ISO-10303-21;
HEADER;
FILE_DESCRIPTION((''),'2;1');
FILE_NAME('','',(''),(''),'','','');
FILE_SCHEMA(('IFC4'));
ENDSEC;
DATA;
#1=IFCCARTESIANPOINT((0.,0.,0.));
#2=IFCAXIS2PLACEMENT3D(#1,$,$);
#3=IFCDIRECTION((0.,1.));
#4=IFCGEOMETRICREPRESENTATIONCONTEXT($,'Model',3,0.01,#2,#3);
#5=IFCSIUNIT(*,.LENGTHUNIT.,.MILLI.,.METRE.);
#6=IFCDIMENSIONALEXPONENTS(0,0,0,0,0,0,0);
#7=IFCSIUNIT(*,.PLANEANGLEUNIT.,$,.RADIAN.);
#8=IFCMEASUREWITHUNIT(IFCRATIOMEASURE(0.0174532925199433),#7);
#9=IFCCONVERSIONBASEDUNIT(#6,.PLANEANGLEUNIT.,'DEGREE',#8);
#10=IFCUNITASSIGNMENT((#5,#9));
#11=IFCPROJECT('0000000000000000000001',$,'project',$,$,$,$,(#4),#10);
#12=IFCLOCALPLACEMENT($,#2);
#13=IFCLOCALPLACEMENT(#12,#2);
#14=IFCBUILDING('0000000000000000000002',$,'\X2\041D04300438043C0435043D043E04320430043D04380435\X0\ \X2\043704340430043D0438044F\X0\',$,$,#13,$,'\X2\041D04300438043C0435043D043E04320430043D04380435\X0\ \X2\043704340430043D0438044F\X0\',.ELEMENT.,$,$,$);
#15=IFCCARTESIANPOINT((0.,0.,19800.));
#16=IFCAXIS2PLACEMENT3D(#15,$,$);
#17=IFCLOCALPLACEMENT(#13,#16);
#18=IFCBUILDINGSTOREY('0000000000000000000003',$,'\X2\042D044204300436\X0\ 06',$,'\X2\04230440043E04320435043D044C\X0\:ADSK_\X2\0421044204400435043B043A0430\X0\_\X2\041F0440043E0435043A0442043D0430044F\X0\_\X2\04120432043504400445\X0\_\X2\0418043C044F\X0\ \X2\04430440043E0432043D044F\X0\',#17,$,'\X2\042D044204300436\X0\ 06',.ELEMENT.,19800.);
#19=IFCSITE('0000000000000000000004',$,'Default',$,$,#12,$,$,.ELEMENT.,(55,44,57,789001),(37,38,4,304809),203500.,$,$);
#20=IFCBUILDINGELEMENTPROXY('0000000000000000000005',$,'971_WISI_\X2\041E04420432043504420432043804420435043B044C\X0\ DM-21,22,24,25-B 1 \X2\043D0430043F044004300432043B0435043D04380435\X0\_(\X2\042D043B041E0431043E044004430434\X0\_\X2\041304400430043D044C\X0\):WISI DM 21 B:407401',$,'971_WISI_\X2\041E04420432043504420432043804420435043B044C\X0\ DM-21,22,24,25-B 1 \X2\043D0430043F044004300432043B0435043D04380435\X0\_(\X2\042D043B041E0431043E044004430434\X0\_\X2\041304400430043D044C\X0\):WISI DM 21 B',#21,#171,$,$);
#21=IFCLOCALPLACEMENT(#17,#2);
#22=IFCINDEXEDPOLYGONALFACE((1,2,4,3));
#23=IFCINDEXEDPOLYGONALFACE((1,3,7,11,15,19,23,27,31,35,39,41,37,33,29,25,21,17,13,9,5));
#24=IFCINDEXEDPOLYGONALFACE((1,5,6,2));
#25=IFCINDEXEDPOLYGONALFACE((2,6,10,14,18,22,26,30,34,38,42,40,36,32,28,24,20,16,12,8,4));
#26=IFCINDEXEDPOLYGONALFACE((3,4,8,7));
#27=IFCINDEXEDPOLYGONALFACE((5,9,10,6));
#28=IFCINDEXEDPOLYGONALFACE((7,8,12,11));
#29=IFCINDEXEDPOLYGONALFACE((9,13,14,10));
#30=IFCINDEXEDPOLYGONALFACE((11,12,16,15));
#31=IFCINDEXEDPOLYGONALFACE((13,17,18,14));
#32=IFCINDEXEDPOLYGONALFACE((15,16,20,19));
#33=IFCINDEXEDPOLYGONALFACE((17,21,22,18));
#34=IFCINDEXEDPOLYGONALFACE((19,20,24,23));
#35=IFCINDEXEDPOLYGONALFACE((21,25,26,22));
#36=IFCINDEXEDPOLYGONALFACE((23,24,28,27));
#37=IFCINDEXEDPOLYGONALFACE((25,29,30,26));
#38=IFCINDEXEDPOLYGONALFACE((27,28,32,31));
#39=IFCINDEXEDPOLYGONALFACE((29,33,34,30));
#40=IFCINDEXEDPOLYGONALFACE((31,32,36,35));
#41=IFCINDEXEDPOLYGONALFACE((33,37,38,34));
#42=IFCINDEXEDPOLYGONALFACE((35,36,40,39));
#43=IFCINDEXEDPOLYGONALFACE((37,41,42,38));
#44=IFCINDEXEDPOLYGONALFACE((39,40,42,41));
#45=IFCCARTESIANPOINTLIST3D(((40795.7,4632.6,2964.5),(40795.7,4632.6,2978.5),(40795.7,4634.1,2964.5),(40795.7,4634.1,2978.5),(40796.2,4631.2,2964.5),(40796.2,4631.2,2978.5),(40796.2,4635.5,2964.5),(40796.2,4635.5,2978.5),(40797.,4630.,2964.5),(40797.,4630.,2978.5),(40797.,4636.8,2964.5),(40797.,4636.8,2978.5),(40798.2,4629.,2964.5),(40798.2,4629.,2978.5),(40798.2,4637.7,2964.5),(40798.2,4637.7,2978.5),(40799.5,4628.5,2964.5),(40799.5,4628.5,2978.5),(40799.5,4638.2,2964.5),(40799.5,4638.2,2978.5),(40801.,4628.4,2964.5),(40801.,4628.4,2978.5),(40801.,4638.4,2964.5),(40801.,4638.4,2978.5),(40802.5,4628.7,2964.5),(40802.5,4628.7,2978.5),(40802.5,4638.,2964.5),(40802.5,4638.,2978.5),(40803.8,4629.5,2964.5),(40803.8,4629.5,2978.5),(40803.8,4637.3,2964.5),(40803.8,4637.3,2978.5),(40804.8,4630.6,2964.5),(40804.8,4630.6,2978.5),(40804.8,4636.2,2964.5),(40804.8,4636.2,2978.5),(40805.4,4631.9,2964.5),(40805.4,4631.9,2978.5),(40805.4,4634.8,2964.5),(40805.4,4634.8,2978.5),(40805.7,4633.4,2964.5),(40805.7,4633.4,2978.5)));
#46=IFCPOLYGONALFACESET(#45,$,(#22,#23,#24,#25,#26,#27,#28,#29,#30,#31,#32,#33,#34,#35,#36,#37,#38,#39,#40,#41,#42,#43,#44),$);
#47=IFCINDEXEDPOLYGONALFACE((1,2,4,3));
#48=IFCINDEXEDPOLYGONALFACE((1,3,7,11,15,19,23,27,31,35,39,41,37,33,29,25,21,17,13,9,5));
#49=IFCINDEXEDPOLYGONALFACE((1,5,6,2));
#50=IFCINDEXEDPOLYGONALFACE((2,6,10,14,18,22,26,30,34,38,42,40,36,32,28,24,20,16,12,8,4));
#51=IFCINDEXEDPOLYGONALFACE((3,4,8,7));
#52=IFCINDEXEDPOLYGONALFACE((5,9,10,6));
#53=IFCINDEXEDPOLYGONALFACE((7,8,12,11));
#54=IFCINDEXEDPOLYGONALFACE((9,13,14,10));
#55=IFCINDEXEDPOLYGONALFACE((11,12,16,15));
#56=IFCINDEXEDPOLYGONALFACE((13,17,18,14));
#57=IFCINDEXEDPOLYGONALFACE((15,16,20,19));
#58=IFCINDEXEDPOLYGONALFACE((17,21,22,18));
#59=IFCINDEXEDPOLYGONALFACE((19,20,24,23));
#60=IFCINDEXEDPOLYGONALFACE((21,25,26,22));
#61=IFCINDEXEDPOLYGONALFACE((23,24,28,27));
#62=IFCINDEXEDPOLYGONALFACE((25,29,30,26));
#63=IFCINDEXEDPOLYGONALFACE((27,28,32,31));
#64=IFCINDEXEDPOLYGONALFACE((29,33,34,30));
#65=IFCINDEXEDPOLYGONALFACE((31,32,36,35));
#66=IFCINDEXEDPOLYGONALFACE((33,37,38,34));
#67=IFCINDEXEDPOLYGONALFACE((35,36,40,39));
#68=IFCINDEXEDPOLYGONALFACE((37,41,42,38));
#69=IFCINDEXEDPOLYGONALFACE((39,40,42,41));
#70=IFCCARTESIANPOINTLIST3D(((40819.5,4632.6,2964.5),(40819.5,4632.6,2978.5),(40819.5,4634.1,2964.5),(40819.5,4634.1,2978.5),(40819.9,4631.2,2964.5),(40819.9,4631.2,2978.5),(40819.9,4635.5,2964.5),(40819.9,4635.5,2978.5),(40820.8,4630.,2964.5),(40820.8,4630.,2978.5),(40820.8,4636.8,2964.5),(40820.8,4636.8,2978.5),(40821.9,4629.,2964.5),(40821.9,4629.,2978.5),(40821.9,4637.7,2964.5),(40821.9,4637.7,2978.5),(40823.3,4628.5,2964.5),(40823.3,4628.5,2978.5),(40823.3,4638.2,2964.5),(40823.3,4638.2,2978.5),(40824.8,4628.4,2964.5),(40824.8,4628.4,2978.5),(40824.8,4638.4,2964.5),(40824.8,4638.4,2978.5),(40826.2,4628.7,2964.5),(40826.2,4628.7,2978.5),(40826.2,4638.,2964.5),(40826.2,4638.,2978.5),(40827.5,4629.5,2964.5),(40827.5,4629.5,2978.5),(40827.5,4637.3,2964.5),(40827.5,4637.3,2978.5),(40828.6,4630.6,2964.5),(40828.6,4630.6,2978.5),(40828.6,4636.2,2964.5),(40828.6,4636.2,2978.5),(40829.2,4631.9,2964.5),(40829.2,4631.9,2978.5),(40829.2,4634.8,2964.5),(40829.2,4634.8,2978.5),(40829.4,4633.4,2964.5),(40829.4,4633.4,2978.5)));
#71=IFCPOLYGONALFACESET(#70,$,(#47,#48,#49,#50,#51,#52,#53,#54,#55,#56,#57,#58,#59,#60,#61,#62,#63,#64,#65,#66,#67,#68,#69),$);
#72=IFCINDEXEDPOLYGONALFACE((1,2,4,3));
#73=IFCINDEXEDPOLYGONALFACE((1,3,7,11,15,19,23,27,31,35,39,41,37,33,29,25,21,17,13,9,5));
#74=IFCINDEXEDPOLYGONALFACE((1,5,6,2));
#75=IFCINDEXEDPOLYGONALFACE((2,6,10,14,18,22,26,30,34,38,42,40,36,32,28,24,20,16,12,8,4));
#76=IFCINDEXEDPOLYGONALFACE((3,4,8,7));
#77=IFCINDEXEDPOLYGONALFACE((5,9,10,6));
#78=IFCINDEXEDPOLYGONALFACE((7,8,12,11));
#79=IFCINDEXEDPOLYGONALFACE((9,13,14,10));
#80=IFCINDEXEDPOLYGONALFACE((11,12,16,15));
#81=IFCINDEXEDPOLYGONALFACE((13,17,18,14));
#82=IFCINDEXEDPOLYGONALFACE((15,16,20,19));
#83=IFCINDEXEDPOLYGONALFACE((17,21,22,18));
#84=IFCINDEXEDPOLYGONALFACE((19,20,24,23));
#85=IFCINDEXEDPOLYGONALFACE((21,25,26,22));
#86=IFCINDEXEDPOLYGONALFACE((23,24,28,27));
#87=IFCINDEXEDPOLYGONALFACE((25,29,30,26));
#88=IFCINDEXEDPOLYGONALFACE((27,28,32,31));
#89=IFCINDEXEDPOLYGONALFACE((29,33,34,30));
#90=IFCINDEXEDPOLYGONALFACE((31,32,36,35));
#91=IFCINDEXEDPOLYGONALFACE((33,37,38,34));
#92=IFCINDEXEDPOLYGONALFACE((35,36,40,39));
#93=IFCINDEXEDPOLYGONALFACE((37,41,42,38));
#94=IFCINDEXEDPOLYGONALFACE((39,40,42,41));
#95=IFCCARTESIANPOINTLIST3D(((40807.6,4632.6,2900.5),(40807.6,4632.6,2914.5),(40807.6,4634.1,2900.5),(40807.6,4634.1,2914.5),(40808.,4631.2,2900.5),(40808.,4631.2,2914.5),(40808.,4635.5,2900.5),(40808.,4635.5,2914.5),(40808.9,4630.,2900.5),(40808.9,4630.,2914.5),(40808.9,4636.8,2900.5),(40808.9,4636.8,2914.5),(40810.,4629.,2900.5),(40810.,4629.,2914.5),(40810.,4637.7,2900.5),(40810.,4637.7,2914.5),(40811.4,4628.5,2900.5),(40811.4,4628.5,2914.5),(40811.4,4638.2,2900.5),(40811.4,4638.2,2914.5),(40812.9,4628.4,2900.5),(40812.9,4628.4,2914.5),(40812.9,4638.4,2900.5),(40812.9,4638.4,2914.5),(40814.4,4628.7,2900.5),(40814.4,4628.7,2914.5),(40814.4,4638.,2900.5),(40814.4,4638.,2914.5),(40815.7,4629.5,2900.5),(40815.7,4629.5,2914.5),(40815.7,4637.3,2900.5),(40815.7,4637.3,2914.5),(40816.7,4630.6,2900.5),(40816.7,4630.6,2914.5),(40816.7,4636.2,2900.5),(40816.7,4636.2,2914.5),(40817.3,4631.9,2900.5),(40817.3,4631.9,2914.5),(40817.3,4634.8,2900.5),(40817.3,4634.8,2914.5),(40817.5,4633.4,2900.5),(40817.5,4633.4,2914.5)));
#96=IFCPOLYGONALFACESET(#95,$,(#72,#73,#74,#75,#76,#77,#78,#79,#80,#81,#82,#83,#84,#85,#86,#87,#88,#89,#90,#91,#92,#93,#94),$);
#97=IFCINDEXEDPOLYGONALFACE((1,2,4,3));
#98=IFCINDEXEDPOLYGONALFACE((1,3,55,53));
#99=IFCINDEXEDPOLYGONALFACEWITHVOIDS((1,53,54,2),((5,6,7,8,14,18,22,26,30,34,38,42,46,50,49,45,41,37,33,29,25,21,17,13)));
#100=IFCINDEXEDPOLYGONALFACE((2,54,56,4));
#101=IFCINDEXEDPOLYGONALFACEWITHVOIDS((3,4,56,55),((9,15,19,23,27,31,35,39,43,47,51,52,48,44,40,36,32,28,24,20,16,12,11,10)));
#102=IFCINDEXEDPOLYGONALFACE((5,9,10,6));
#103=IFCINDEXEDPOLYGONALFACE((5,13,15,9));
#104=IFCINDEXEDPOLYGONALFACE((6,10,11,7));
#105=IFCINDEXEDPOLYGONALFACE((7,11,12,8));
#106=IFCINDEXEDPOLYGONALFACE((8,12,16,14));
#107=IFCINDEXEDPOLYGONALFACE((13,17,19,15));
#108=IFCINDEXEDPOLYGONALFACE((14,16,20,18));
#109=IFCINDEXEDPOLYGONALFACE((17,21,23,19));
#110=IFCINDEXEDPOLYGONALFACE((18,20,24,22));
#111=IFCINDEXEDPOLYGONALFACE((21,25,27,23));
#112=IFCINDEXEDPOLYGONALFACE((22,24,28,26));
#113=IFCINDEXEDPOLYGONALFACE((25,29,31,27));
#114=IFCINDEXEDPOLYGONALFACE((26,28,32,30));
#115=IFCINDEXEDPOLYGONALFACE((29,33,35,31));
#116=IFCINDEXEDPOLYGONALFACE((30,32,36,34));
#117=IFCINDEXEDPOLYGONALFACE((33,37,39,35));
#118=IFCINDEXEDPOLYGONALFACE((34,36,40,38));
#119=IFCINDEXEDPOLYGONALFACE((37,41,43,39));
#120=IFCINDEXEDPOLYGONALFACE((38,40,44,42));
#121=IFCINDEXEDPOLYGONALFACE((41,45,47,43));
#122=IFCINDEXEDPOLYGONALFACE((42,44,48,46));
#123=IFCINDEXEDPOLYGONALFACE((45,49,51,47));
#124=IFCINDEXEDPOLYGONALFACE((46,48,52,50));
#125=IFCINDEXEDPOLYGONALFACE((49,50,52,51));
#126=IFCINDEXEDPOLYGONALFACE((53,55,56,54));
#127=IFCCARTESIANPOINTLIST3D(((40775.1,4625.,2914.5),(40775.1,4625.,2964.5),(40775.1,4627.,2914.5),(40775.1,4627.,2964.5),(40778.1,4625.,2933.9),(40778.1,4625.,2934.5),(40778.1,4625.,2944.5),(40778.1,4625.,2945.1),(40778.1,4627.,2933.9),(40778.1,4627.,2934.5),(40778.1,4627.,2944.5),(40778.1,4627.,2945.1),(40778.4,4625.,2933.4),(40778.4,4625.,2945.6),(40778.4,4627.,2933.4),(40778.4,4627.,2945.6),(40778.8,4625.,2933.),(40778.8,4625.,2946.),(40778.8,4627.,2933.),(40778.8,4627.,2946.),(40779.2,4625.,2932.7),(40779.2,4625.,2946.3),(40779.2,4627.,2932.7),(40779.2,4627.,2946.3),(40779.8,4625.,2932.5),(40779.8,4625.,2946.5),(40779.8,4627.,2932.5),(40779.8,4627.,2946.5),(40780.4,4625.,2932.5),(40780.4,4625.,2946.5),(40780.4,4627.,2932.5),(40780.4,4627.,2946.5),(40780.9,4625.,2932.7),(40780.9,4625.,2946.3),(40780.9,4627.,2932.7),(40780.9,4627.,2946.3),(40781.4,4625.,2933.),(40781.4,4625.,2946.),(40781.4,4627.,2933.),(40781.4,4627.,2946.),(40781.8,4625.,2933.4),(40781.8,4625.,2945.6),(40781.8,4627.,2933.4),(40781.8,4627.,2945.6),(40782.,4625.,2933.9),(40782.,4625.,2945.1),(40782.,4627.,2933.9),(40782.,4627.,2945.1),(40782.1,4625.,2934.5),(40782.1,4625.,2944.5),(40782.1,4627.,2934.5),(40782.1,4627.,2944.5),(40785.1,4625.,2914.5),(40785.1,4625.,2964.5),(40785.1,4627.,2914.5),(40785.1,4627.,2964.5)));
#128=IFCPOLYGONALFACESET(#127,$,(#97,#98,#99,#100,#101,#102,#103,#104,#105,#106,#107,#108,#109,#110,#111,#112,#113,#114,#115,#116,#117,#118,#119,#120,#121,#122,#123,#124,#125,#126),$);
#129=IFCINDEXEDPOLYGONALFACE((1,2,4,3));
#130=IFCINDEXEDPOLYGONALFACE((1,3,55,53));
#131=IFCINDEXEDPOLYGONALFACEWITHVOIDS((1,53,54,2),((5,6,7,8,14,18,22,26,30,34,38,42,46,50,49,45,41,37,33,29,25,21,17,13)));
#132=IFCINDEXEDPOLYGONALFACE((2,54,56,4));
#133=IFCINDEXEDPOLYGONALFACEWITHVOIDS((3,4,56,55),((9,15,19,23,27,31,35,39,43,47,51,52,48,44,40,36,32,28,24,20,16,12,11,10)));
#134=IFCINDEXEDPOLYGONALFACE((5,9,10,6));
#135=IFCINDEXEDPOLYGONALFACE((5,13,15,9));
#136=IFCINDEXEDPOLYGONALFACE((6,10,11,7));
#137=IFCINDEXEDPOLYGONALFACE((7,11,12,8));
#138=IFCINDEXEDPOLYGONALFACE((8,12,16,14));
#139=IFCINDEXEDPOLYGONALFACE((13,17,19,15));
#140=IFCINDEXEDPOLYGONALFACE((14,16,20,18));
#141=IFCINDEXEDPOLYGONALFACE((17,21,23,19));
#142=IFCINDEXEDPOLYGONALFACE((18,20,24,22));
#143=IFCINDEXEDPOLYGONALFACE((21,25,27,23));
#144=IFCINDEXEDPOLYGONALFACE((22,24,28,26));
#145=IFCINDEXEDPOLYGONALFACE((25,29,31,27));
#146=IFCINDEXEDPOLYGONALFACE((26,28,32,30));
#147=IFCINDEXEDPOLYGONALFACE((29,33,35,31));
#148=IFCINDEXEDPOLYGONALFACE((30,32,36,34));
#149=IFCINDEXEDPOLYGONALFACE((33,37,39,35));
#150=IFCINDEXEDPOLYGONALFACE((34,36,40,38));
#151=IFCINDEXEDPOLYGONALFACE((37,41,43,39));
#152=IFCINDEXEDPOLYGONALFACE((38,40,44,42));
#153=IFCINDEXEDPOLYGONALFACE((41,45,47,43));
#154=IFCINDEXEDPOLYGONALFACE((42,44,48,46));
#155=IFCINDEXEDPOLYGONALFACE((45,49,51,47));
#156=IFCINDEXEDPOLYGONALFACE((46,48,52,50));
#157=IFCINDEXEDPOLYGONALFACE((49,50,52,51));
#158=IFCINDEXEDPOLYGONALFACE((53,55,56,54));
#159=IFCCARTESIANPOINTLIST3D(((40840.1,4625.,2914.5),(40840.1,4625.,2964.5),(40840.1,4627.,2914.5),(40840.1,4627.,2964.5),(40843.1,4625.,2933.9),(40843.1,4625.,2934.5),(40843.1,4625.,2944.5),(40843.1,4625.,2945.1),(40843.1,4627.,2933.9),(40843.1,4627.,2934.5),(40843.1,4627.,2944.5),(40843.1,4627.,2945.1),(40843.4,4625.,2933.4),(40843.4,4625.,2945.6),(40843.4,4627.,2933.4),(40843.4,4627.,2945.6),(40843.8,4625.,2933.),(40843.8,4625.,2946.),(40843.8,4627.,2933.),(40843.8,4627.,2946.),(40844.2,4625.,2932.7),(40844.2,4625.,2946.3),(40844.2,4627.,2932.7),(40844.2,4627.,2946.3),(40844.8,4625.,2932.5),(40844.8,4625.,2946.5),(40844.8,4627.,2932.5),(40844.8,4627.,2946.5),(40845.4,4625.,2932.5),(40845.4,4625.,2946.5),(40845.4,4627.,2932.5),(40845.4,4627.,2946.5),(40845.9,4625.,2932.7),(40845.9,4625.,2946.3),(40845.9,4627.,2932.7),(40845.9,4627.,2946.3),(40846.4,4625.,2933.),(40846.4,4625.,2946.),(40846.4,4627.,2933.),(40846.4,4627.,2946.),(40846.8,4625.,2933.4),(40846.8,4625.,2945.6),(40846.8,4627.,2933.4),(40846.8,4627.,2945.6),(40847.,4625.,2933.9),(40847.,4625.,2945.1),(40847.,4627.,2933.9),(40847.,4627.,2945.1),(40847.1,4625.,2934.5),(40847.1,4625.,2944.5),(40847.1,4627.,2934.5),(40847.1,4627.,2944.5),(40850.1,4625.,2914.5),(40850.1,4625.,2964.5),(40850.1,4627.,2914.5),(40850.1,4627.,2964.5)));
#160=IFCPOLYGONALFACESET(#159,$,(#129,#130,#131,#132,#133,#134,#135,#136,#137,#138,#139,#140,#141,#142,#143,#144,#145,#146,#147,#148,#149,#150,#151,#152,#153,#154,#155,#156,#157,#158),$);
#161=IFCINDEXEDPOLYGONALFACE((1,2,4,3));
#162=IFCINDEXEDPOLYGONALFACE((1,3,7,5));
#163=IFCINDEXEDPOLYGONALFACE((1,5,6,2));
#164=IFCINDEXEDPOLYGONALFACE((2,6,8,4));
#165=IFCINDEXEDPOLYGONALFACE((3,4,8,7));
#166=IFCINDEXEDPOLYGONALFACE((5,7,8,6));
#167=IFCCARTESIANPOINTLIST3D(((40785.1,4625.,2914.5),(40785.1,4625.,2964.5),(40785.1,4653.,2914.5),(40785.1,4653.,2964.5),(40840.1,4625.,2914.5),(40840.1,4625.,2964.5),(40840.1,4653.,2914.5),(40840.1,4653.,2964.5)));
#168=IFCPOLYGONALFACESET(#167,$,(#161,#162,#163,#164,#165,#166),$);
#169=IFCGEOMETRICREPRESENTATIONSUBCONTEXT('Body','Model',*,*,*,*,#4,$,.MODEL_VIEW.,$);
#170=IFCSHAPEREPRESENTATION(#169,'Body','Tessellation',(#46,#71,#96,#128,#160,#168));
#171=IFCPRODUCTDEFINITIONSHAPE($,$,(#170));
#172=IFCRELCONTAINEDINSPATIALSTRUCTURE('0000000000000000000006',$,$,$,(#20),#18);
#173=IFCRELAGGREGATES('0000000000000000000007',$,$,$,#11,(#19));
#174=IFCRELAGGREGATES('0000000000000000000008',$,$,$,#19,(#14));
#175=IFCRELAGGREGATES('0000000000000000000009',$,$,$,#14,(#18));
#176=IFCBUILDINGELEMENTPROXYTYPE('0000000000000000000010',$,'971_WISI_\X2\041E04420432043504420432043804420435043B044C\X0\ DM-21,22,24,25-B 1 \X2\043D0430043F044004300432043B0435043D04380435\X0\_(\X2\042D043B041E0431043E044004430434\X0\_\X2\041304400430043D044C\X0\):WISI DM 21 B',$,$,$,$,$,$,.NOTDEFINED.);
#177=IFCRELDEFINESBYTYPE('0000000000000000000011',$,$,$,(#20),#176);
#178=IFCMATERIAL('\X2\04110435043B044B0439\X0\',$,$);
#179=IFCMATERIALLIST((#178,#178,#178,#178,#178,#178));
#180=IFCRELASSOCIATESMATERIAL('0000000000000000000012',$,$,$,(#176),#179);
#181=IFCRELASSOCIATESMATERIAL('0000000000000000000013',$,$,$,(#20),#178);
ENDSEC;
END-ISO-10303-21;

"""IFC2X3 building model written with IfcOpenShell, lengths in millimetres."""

from ifc_helpers import new_model, entity, si_unit, converted_unit, direction, frame, frame_2d, origin, place, context, subcontext, project, spatial, polyline, circle_curve, parameter, trimmed, segment, composite_curve, rectangle, circle, outline, extrude, source, transform, mapped, material, material_list, type_object, type_shapes, element, save


model = new_model("IFC2X3")

# Units and contexts
model_context = context("Model", 3, precision=0.01, world=origin(), true_north=direction((0.0, 1.0)))
body_context = subcontext(model_context, "Body", "Model", "MODEL_VIEW")
ifc_project = project(units=[si_unit("LENGTHUNIT", "METRE", prefix="MILLI"), converted_unit("PLANEANGLEUNIT", "DEGREE", entity("IfcRatioMeasure", 0.0174532925199433), si_unit("PLANEANGLEUNIT", "RADIAN"), dimensions=[0, 0, 0, 0, 0, 0, 0])], contexts=[model_context])

# Site, building, storey
site_placement = place(None, frame((0.0, 0.0, 0.0)))
site = spatial("IfcSite", under=ifc_project, at=site_placement, Name="Default", CompositionType="ELEMENT", RefLatitude=(55, 44, 57, 789001), RefLongitude=(37, 38, 4, 304809), RefElevation=203500.0)
building_placement = place(site_placement, origin())
building = spatial("IfcBuilding", under=site, at=building_placement, Name="Наименование здания", LongName="Наименование здания", CompositionType="ELEMENT")
storey_placement = place(building_placement, frame((0.0, 0.0, 19800.0)))
storey = spatial("IfcBuildingStorey", under=building, at=storey_placement, Name="Этаж 06", ObjectType="Уровень:ADSK_Стрелка_Проектная_Вверх_Имя уровня", LongName="Этаж 06", CompositionType="ELEMENT", Elevation=19800.0)

# Building element proxy
ifc_material_1 = material(Name="Белый")
ifc_material_list_1 = material_list([ifc_material_1, ifc_material_1, ifc_material_1, ifc_material_1, ifc_material_1, ifc_material_1])
building_element_proxy_type_1 = type_object("IfcBuildingElementProxyType", Name="971_WISI_Ответвитель DM-21,22,24,25-B 1 направление_(ЭлОборуд_Грань):WISI DM 21 B", PredefinedType="NOTDEFINED", material=ifc_material_list_1)
shared_shape_1 = source(origin(), body_context, "Body", "SweptSolid", [
    extrude(circle(Radius=5.0, at=frame_2d((0.0, 0.0), x_axis=(1.0, 0.0))), frame((11.9, 25.0, 8.4), z_axis=(0.0, 1.0, 0.0), x_axis=(-1.0, 0.0, 0.0)), (0.0, 0.0, 1.0), 14.0),
    extrude(circle(Radius=5.0, at=frame_2d((0.0, 0.0), x_axis=(1.0, 0.0))), frame((-11.8, 25.0, 8.4), z_axis=(0.0, 1.0, 0.0), x_axis=(-1.0, 0.0, 0.0)), (0.0, 0.0, 1.0), 14.0),
    extrude(circle(Radius=5.0, at=frame_2d((0.0, 0.0), x_axis=(1.0, 0.0))), frame((0.0, -39.0, 8.4), z_axis=(0.0, 1.0, 0.0), x_axis=(-1.0, 0.0, 0.0)), (0.0, 0.0, 1.0), 14.0),
    extrude(outline(polyline([(-5.0, -25.0), (5.0, -25.0), (5.0, 25.0), (-5.0, 25.0), (-5.0, -25.0)]), holes=[composite_curve([segment(polyline([(2.0, 5.0), (2.0, -5.0)]), True, "CONTINUOUS"), segment(trimmed(circle_curve(frame_2d((0.0, -5.0), x_axis=(-1.0, 0.0)), 2.0), [parameter(0.0)], [parameter(180.0)], True, "PARAMETER"), False, "CONTINUOUS"), segment(polyline([(-2.0, -5.0), (-2.0, 5.0)]), True, "CONTINUOUS"), segment(trimmed(circle_curve(frame_2d((0.0, 5.0), x_axis=(-1.0, 0.0)), 2.0), [parameter(180.0)], [parameter(0.0)], True, "PARAMETER"), False, "CONTINUOUS")], self_intersect=False)]), frame((32.5, 0.0, 0.0), z_axis=(0.0, 0.0, 1.0), x_axis=(-1.0, 0.0, 0.0)), (0.0, 0.0, 1.0), 2.0),
    extrude(outline(polyline([(-5.0, -25.0), (5.0, -25.0), (5.0, 25.0), (-5.0, 25.0), (-5.0, -25.0)]), holes=[composite_curve([segment(polyline([(-2.0, -5.0), (-2.0, 5.0)]), True, "CONTINUOUS"), segment(trimmed(circle_curve(frame_2d((0.0, 5.0), x_axis=(-1.0, 0.0)), 2.0), [parameter(180.0)], [parameter(0.0)], True, "PARAMETER"), False, "CONTINUOUS"), segment(polyline([(2.0, 5.0), (2.0, -5.0)]), True, "CONTINUOUS"), segment(trimmed(circle_curve(frame_2d((0.0, -5.0), x_axis=(-1.0, 0.0)), 2.0), [parameter(0.0)], [parameter(180.0)], True, "PARAMETER"), False, "CONTINUOUS")], self_intersect=False)]), frame((-32.5, 0.0, 0.0), z_axis=(0.0, 0.0, 1.0), x_axis=(-1.0, 0.0, 0.0)), (0.0, 0.0, 1.0), 2.0),
    extrude(rectangle(XDim=55.0, YDim=50.0, at=frame_2d((0.0, 0.0), x_axis=(1.0, 0.0))), frame((0.0, 0.0, 0.0), z_axis=(0.0, 0.0, 1.0), x_axis=(-1.0, 0.0, 0.0)), (0.0, 0.0, 1.0), 28.0),
])
type_shapes(building_element_proxy_type_1, [shared_shape_1])
for number, where, z_axis, x_axis, name in (
    (1, (40812.6, 4625.0, 2939.5), (0.0, 1.0, 0.0), (-1.0, 0.0, 0.0), "971_WISI_Ответвитель DM-21,22,24,25-B 1 направление_(ЭлОборуд_Грань):WISI DM 21 B:407401"),
):
    element("IfcBuildingElementProxy", number, at=place(storey_placement, frame(where, z_axis=z_axis, x_axis=x_axis)), inside=storey, type_object=building_element_proxy_type_1, material=ifc_material_1, Name=name, ObjectType="971_WISI_Ответвитель DM-21,22,24,25-B 1 направление_(ЭлОборуд_Грань):WISI DM 21 B", context=body_context, shape_type="MappedRepresentation", body=[
        mapped(shared_shape_1, transform((0.0, 0.0, 0.0), scale=1.0)),
    ])

save(model, "model.ifc")
